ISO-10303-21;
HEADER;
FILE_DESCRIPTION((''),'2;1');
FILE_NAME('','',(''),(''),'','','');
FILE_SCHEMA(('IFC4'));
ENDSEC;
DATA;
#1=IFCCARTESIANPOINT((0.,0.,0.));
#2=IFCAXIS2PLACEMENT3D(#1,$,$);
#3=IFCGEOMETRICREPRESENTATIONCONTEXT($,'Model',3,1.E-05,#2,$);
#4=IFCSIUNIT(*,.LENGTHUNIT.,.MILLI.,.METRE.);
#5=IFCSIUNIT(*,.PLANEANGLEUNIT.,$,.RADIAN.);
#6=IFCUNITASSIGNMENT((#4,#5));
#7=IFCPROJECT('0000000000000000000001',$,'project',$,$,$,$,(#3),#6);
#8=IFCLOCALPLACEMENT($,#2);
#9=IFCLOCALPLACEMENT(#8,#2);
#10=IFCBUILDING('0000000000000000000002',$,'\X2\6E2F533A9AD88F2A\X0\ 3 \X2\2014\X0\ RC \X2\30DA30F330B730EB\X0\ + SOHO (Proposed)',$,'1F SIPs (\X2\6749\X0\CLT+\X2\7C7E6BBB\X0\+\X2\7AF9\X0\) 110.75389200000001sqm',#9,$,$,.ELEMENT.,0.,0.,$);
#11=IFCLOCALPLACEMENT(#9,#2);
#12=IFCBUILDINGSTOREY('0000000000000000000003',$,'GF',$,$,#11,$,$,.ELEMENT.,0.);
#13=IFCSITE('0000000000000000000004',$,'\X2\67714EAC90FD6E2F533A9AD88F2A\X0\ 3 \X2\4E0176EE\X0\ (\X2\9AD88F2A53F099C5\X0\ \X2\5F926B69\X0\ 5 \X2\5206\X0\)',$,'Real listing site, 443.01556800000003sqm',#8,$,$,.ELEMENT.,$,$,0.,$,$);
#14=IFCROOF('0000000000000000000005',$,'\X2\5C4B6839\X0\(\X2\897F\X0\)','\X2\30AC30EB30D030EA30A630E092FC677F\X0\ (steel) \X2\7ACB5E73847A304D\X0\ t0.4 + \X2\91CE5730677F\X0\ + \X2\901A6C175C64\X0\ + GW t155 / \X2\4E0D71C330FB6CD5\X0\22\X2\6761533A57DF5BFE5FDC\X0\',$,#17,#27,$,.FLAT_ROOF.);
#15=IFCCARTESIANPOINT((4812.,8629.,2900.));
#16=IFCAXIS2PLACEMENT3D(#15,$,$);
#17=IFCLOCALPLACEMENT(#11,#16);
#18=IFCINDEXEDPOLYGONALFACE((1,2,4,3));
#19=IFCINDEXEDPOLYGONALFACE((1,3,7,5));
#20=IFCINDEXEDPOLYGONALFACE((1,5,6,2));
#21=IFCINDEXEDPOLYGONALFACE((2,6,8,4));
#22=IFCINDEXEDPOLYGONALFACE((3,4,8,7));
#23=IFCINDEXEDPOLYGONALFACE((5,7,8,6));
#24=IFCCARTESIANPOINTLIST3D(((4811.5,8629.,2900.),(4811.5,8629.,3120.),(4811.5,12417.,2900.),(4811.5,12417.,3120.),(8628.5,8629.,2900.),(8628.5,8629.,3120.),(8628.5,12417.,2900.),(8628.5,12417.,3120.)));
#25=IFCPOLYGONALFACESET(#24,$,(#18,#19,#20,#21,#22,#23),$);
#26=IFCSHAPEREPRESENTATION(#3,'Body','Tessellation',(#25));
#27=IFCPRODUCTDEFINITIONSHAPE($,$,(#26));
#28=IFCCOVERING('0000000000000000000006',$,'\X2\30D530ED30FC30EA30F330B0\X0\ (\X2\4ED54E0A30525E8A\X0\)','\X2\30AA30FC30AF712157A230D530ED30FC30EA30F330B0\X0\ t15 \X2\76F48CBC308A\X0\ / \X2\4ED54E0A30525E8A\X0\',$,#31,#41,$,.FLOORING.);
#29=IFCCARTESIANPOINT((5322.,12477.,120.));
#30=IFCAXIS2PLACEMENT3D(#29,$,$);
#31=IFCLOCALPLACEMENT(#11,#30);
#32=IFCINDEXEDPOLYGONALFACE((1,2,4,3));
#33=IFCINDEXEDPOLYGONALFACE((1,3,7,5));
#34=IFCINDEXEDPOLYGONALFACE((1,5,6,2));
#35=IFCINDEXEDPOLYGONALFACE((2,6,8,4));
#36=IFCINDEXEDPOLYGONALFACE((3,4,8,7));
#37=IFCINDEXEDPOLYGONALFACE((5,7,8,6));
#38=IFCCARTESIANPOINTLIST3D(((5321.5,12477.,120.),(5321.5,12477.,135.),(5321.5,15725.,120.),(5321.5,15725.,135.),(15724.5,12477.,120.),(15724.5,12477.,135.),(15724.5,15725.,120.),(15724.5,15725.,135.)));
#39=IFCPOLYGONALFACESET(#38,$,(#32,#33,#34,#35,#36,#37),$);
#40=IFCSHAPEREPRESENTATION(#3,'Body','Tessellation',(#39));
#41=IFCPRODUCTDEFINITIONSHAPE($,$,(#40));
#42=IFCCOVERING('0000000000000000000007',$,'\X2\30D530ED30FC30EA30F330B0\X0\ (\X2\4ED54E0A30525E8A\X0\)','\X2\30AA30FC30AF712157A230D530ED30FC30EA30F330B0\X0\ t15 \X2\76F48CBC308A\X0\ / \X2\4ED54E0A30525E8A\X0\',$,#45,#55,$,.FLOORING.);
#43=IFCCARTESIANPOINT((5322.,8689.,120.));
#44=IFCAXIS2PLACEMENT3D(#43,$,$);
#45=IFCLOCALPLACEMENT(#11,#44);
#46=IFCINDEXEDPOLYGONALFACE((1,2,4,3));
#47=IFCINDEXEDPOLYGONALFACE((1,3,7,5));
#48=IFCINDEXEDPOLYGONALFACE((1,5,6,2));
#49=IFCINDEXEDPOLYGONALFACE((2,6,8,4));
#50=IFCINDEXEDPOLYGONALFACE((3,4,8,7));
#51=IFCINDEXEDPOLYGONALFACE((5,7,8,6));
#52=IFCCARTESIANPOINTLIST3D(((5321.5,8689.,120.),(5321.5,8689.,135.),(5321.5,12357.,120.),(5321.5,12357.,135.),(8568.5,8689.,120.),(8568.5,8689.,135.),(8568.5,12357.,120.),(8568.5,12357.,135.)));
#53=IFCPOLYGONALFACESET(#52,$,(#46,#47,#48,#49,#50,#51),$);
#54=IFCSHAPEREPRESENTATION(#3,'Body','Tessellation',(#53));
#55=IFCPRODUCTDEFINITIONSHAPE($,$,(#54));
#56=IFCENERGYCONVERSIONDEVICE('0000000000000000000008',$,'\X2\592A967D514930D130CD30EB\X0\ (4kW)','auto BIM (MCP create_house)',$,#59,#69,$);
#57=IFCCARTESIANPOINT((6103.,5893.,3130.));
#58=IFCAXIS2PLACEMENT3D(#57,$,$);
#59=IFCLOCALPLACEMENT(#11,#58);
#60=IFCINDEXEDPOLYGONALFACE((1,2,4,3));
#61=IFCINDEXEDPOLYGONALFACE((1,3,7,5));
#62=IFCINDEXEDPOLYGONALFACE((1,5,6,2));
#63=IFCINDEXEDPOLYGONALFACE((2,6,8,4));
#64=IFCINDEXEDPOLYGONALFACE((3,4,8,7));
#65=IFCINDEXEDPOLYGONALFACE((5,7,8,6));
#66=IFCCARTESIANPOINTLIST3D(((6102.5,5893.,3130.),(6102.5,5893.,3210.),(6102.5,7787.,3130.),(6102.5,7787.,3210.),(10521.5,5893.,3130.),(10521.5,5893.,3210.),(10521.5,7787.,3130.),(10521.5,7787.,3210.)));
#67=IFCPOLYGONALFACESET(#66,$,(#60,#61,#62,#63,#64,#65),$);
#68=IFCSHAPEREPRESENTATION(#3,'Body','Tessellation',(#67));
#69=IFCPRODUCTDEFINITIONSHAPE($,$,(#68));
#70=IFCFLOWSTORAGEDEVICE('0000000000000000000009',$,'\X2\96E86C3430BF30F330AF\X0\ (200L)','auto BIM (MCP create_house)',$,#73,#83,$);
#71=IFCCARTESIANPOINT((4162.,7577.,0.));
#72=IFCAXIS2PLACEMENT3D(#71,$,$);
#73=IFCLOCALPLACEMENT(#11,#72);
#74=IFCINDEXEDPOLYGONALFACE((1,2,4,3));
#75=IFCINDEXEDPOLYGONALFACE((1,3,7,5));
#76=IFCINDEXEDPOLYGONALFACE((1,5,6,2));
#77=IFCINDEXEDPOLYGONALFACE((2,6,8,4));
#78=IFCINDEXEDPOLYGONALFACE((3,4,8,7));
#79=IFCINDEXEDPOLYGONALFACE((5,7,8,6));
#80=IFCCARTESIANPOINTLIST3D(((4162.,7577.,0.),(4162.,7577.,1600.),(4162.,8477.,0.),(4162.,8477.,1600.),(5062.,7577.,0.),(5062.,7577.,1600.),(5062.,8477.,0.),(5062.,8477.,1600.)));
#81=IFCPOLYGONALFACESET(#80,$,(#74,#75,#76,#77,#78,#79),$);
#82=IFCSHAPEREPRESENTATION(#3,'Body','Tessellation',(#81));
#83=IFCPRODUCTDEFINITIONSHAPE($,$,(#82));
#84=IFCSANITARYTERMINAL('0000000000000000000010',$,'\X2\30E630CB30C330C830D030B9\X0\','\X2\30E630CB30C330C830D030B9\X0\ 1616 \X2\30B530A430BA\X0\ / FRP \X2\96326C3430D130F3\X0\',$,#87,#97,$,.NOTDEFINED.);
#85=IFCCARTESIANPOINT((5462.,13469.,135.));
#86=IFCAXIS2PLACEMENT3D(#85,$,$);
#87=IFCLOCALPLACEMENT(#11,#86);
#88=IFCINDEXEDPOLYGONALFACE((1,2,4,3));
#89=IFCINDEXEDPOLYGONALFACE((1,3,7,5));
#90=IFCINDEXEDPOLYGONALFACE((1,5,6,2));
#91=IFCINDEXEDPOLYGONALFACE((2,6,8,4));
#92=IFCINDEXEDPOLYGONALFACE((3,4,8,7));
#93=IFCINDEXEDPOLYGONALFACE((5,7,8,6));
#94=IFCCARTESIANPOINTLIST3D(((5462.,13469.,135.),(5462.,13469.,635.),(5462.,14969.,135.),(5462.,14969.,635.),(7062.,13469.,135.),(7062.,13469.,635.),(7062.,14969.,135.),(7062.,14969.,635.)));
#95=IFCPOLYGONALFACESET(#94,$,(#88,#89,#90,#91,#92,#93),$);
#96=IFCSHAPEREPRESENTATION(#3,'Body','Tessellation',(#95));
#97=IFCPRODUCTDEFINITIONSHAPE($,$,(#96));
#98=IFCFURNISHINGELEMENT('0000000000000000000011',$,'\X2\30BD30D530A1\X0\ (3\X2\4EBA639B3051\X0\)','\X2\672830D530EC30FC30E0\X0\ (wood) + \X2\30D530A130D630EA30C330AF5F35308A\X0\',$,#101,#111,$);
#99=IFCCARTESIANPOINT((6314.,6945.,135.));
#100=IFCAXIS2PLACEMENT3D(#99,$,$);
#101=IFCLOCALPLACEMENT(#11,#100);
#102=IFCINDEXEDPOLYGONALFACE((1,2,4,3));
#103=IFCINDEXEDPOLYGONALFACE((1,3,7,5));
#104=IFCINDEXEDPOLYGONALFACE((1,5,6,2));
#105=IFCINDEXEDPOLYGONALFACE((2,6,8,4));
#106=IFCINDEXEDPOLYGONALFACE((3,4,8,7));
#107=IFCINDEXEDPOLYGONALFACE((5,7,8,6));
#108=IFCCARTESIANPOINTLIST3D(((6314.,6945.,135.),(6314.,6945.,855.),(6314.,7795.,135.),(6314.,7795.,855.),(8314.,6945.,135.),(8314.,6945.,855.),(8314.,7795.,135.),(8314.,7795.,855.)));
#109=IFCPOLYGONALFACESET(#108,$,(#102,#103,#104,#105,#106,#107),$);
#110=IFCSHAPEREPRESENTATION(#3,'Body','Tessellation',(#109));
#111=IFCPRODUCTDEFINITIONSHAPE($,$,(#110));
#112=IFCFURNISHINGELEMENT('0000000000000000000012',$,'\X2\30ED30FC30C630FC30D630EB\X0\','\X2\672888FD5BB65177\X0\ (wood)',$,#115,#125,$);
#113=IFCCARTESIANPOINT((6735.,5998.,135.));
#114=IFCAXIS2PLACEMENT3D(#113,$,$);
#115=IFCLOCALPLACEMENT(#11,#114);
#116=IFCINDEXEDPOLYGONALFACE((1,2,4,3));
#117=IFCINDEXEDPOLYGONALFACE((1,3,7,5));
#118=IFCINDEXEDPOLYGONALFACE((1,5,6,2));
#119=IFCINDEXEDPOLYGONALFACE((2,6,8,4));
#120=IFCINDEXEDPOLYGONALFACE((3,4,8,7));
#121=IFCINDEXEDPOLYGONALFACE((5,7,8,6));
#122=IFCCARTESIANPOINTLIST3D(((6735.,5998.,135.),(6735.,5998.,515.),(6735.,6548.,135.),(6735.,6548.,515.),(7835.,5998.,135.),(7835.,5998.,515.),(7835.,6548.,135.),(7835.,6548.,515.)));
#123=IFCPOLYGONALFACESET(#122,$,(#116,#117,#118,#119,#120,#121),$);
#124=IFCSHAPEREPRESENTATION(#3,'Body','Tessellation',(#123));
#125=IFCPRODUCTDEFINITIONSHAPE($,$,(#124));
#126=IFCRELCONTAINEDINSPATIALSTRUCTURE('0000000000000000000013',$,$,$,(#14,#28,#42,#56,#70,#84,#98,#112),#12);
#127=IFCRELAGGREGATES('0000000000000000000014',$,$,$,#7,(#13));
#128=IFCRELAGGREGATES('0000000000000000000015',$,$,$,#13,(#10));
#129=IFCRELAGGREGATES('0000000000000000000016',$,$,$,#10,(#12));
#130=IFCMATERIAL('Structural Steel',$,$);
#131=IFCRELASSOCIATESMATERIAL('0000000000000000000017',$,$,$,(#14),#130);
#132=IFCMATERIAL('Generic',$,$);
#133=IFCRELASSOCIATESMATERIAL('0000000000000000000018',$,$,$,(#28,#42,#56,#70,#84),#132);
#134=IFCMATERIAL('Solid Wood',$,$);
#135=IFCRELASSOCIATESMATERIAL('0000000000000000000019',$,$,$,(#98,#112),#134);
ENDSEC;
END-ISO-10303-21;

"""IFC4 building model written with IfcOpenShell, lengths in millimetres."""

from ifc_helpers import new_model, si_unit, frame, frame_2d, origin, place, context, project, spatial, rectangle, extrude, material, element, save


model = new_model("IFC4")

# Units and contexts
model_context = context("Model", 3, precision=1e-05, world=origin())
ifc_project = project(units=[si_unit("LENGTHUNIT", "METRE", prefix="MILLI"), si_unit("PLANEANGLEUNIT", "RADIAN")], contexts=[model_context])

# Site, building, storey
site_placement = place(None, origin())
site = spatial("IfcSite", under=ifc_project, at=site_placement, Name="東京都港区高輪 3 丁目 (高輪台駅 徒歩 5 分)", ObjectType="Real listing site, 443.01556800000003sqm", CompositionType="ELEMENT", RefElevation=0.0)
building_placement = place(site_placement, origin())
building = spatial("IfcBuilding", under=site, at=building_placement, Name="港区高輪 3 — RC ペンシル + SOHO (Proposed)", ObjectType="1F SIPs (杉CLT+籾殻+竹) 110.75389200000001sqm", CompositionType="ELEMENT", ElevationOfRefHeight=0.0, ElevationOfTerrain=0.0)
storey_placement = place(building_placement, origin())
storey = spatial("IfcBuildingStorey", under=building, at=storey_placement, Name="GF", CompositionType="ELEMENT", Elevation=0.0)

# Shared definitions
ifc_material_1 = material(Name="Solid Wood")

# Roof
ifc_material_2 = material(Name="Structural Steel")
roof_1_placement = place(storey_placement, frame((4812.0, 8629.0, 2900.0)))
element("IfcRoof", 1, at=roof_1_placement, inside=storey, material=ifc_material_2, Name="屋根(西)", Description="ガルバリウム鋼板 (steel) 立平葺き t0.4 + 野地板 + 通気層 + GW t155 / 不燃・法22条区域対応", PredefinedType="FLAT_ROOF", context=model_context, shape_type="SweptSolid", body=[
    extrude(rectangle(XDim=3817.0, YDim=3788.0, at=frame_2d((1908.0, 1894.0))), frame((4812.0, 8629.0, 2900.0)), (0.0, 0.0, 1.0), 220.0),
])

# Coverings
ifc_material_3 = material(Name="Generic")
covering_1_placement = place(storey_placement, frame((5322.0, 12477.0, 120.0)))
element("IfcCovering", 2, at=covering_1_placement, inside=storey, material=ifc_material_3, Name="フローリング (仕上げ床)", Description="オーク無垢フローリング t15 直貼り / 仕上げ床", PredefinedType="FLOORING", context=model_context, shape_type="SweptSolid", body=[
    extrude(rectangle(XDim=10403.0, YDim=3248.0, at=frame_2d((5201.0, 1624.0))), frame((5322.0, 12477.0, 120.0)), (0.0, 0.0, 1.0), 15.0),
])
covering_2_placement = place(storey_placement, frame((5322.0, 8689.0, 120.0)))
element("IfcCovering", 3, at=covering_2_placement, inside=storey, material=ifc_material_3, Name="フローリング (仕上げ床)", Description="オーク無垢フローリング t15 直貼り / 仕上げ床", PredefinedType="FLOORING", context=model_context, shape_type="SweptSolid", body=[
    extrude(rectangle(XDim=3247.0, YDim=3668.0, at=frame_2d((1623.0, 1834.0))), frame((5322.0, 8689.0, 120.0)), (0.0, 0.0, 1.0), 15.0),
])

# Energy conversion device
energy_conversion_device_placement = place(storey_placement, frame((6103.0, 5893.0, 3130.0)))
element("IfcEnergyConversionDevice", 4, at=energy_conversion_device_placement, inside=storey, material=ifc_material_3, Name="太陽光パネル (4kW)", Description="auto BIM (MCP create_house)", context=model_context, shape_type="SweptSolid", body=[
    extrude(rectangle(XDim=4419.0, YDim=1894.0, at=frame_2d((2209.0, 947.0))), frame((6103.0, 5893.0, 3130.0)), (0.0, 0.0, 1.0), 80.0),
])

# Flow storage device
flow_storage_device_placement = place(storey_placement, frame((4162.0, 7577.0, 0.0)))
element("IfcFlowStorageDevice", 5, at=flow_storage_device_placement, inside=storey, material=ifc_material_3, Name="雨水タンク (200L)", Description="auto BIM (MCP create_house)", context=model_context, shape_type="SweptSolid", body=[
    extrude(rectangle(XDim=900.0, YDim=900.0, at=frame_2d((450.0, 450.0))), frame((4162.0, 7577.0, 0.0)), (0.0, 0.0, 1.0), 1600.0),
])

# Sanitary terminal
sanitary_terminal_placement = place(storey_placement, frame((5462.0, 13469.0, 135.0)))
element("IfcSanitaryTerminal", 6, at=sanitary_terminal_placement, inside=storey, material=ifc_material_3, Name="ユニットバス", Description="ユニットバス 1616 サイズ / FRP 防水パン", PredefinedType="NOTDEFINED", context=model_context, shape_type="SweptSolid", body=[
    extrude(rectangle(XDim=1600.0, YDim=1500.0, at=frame_2d((800.0, 750.0))), frame((5462.0, 13469.0, 135.0)), (0.0, 0.0, 1.0), 500.0),
])

# Furnishing elements
furnishing_1_placement = place(storey_placement, frame((6314.0, 6945.0, 135.0)))
element("IfcFurnishingElement", 7, at=furnishing_1_placement, inside=storey, material=ifc_material_1, Name="ソファ (3人掛け)", Description="木フレーム (wood) + ファブリック張り", context=model_context, shape_type="SweptSolid", body=[
    extrude(rectangle(XDim=2000.0, YDim=850.0, at=frame_2d((1000.0, 425.0))), frame((6314.0, 6945.0, 135.0)), (0.0, 0.0, 1.0), 720.0),
])
furnishing_2_placement = place(storey_placement, frame((6735.0, 5998.0, 135.0)))
element("IfcFurnishingElement", 8, at=furnishing_2_placement, inside=storey, material=ifc_material_1, Name="ローテーブル", Description="木製家具 (wood)", context=model_context, shape_type="SweptSolid", body=[
    extrude(rectangle(XDim=1100.0, YDim=550.0, at=frame_2d((550.0, 275.0))), frame((6735.0, 5998.0, 135.0)), (0.0, 0.0, 1.0), 380.0),
])

save(model, "model.ifc")
